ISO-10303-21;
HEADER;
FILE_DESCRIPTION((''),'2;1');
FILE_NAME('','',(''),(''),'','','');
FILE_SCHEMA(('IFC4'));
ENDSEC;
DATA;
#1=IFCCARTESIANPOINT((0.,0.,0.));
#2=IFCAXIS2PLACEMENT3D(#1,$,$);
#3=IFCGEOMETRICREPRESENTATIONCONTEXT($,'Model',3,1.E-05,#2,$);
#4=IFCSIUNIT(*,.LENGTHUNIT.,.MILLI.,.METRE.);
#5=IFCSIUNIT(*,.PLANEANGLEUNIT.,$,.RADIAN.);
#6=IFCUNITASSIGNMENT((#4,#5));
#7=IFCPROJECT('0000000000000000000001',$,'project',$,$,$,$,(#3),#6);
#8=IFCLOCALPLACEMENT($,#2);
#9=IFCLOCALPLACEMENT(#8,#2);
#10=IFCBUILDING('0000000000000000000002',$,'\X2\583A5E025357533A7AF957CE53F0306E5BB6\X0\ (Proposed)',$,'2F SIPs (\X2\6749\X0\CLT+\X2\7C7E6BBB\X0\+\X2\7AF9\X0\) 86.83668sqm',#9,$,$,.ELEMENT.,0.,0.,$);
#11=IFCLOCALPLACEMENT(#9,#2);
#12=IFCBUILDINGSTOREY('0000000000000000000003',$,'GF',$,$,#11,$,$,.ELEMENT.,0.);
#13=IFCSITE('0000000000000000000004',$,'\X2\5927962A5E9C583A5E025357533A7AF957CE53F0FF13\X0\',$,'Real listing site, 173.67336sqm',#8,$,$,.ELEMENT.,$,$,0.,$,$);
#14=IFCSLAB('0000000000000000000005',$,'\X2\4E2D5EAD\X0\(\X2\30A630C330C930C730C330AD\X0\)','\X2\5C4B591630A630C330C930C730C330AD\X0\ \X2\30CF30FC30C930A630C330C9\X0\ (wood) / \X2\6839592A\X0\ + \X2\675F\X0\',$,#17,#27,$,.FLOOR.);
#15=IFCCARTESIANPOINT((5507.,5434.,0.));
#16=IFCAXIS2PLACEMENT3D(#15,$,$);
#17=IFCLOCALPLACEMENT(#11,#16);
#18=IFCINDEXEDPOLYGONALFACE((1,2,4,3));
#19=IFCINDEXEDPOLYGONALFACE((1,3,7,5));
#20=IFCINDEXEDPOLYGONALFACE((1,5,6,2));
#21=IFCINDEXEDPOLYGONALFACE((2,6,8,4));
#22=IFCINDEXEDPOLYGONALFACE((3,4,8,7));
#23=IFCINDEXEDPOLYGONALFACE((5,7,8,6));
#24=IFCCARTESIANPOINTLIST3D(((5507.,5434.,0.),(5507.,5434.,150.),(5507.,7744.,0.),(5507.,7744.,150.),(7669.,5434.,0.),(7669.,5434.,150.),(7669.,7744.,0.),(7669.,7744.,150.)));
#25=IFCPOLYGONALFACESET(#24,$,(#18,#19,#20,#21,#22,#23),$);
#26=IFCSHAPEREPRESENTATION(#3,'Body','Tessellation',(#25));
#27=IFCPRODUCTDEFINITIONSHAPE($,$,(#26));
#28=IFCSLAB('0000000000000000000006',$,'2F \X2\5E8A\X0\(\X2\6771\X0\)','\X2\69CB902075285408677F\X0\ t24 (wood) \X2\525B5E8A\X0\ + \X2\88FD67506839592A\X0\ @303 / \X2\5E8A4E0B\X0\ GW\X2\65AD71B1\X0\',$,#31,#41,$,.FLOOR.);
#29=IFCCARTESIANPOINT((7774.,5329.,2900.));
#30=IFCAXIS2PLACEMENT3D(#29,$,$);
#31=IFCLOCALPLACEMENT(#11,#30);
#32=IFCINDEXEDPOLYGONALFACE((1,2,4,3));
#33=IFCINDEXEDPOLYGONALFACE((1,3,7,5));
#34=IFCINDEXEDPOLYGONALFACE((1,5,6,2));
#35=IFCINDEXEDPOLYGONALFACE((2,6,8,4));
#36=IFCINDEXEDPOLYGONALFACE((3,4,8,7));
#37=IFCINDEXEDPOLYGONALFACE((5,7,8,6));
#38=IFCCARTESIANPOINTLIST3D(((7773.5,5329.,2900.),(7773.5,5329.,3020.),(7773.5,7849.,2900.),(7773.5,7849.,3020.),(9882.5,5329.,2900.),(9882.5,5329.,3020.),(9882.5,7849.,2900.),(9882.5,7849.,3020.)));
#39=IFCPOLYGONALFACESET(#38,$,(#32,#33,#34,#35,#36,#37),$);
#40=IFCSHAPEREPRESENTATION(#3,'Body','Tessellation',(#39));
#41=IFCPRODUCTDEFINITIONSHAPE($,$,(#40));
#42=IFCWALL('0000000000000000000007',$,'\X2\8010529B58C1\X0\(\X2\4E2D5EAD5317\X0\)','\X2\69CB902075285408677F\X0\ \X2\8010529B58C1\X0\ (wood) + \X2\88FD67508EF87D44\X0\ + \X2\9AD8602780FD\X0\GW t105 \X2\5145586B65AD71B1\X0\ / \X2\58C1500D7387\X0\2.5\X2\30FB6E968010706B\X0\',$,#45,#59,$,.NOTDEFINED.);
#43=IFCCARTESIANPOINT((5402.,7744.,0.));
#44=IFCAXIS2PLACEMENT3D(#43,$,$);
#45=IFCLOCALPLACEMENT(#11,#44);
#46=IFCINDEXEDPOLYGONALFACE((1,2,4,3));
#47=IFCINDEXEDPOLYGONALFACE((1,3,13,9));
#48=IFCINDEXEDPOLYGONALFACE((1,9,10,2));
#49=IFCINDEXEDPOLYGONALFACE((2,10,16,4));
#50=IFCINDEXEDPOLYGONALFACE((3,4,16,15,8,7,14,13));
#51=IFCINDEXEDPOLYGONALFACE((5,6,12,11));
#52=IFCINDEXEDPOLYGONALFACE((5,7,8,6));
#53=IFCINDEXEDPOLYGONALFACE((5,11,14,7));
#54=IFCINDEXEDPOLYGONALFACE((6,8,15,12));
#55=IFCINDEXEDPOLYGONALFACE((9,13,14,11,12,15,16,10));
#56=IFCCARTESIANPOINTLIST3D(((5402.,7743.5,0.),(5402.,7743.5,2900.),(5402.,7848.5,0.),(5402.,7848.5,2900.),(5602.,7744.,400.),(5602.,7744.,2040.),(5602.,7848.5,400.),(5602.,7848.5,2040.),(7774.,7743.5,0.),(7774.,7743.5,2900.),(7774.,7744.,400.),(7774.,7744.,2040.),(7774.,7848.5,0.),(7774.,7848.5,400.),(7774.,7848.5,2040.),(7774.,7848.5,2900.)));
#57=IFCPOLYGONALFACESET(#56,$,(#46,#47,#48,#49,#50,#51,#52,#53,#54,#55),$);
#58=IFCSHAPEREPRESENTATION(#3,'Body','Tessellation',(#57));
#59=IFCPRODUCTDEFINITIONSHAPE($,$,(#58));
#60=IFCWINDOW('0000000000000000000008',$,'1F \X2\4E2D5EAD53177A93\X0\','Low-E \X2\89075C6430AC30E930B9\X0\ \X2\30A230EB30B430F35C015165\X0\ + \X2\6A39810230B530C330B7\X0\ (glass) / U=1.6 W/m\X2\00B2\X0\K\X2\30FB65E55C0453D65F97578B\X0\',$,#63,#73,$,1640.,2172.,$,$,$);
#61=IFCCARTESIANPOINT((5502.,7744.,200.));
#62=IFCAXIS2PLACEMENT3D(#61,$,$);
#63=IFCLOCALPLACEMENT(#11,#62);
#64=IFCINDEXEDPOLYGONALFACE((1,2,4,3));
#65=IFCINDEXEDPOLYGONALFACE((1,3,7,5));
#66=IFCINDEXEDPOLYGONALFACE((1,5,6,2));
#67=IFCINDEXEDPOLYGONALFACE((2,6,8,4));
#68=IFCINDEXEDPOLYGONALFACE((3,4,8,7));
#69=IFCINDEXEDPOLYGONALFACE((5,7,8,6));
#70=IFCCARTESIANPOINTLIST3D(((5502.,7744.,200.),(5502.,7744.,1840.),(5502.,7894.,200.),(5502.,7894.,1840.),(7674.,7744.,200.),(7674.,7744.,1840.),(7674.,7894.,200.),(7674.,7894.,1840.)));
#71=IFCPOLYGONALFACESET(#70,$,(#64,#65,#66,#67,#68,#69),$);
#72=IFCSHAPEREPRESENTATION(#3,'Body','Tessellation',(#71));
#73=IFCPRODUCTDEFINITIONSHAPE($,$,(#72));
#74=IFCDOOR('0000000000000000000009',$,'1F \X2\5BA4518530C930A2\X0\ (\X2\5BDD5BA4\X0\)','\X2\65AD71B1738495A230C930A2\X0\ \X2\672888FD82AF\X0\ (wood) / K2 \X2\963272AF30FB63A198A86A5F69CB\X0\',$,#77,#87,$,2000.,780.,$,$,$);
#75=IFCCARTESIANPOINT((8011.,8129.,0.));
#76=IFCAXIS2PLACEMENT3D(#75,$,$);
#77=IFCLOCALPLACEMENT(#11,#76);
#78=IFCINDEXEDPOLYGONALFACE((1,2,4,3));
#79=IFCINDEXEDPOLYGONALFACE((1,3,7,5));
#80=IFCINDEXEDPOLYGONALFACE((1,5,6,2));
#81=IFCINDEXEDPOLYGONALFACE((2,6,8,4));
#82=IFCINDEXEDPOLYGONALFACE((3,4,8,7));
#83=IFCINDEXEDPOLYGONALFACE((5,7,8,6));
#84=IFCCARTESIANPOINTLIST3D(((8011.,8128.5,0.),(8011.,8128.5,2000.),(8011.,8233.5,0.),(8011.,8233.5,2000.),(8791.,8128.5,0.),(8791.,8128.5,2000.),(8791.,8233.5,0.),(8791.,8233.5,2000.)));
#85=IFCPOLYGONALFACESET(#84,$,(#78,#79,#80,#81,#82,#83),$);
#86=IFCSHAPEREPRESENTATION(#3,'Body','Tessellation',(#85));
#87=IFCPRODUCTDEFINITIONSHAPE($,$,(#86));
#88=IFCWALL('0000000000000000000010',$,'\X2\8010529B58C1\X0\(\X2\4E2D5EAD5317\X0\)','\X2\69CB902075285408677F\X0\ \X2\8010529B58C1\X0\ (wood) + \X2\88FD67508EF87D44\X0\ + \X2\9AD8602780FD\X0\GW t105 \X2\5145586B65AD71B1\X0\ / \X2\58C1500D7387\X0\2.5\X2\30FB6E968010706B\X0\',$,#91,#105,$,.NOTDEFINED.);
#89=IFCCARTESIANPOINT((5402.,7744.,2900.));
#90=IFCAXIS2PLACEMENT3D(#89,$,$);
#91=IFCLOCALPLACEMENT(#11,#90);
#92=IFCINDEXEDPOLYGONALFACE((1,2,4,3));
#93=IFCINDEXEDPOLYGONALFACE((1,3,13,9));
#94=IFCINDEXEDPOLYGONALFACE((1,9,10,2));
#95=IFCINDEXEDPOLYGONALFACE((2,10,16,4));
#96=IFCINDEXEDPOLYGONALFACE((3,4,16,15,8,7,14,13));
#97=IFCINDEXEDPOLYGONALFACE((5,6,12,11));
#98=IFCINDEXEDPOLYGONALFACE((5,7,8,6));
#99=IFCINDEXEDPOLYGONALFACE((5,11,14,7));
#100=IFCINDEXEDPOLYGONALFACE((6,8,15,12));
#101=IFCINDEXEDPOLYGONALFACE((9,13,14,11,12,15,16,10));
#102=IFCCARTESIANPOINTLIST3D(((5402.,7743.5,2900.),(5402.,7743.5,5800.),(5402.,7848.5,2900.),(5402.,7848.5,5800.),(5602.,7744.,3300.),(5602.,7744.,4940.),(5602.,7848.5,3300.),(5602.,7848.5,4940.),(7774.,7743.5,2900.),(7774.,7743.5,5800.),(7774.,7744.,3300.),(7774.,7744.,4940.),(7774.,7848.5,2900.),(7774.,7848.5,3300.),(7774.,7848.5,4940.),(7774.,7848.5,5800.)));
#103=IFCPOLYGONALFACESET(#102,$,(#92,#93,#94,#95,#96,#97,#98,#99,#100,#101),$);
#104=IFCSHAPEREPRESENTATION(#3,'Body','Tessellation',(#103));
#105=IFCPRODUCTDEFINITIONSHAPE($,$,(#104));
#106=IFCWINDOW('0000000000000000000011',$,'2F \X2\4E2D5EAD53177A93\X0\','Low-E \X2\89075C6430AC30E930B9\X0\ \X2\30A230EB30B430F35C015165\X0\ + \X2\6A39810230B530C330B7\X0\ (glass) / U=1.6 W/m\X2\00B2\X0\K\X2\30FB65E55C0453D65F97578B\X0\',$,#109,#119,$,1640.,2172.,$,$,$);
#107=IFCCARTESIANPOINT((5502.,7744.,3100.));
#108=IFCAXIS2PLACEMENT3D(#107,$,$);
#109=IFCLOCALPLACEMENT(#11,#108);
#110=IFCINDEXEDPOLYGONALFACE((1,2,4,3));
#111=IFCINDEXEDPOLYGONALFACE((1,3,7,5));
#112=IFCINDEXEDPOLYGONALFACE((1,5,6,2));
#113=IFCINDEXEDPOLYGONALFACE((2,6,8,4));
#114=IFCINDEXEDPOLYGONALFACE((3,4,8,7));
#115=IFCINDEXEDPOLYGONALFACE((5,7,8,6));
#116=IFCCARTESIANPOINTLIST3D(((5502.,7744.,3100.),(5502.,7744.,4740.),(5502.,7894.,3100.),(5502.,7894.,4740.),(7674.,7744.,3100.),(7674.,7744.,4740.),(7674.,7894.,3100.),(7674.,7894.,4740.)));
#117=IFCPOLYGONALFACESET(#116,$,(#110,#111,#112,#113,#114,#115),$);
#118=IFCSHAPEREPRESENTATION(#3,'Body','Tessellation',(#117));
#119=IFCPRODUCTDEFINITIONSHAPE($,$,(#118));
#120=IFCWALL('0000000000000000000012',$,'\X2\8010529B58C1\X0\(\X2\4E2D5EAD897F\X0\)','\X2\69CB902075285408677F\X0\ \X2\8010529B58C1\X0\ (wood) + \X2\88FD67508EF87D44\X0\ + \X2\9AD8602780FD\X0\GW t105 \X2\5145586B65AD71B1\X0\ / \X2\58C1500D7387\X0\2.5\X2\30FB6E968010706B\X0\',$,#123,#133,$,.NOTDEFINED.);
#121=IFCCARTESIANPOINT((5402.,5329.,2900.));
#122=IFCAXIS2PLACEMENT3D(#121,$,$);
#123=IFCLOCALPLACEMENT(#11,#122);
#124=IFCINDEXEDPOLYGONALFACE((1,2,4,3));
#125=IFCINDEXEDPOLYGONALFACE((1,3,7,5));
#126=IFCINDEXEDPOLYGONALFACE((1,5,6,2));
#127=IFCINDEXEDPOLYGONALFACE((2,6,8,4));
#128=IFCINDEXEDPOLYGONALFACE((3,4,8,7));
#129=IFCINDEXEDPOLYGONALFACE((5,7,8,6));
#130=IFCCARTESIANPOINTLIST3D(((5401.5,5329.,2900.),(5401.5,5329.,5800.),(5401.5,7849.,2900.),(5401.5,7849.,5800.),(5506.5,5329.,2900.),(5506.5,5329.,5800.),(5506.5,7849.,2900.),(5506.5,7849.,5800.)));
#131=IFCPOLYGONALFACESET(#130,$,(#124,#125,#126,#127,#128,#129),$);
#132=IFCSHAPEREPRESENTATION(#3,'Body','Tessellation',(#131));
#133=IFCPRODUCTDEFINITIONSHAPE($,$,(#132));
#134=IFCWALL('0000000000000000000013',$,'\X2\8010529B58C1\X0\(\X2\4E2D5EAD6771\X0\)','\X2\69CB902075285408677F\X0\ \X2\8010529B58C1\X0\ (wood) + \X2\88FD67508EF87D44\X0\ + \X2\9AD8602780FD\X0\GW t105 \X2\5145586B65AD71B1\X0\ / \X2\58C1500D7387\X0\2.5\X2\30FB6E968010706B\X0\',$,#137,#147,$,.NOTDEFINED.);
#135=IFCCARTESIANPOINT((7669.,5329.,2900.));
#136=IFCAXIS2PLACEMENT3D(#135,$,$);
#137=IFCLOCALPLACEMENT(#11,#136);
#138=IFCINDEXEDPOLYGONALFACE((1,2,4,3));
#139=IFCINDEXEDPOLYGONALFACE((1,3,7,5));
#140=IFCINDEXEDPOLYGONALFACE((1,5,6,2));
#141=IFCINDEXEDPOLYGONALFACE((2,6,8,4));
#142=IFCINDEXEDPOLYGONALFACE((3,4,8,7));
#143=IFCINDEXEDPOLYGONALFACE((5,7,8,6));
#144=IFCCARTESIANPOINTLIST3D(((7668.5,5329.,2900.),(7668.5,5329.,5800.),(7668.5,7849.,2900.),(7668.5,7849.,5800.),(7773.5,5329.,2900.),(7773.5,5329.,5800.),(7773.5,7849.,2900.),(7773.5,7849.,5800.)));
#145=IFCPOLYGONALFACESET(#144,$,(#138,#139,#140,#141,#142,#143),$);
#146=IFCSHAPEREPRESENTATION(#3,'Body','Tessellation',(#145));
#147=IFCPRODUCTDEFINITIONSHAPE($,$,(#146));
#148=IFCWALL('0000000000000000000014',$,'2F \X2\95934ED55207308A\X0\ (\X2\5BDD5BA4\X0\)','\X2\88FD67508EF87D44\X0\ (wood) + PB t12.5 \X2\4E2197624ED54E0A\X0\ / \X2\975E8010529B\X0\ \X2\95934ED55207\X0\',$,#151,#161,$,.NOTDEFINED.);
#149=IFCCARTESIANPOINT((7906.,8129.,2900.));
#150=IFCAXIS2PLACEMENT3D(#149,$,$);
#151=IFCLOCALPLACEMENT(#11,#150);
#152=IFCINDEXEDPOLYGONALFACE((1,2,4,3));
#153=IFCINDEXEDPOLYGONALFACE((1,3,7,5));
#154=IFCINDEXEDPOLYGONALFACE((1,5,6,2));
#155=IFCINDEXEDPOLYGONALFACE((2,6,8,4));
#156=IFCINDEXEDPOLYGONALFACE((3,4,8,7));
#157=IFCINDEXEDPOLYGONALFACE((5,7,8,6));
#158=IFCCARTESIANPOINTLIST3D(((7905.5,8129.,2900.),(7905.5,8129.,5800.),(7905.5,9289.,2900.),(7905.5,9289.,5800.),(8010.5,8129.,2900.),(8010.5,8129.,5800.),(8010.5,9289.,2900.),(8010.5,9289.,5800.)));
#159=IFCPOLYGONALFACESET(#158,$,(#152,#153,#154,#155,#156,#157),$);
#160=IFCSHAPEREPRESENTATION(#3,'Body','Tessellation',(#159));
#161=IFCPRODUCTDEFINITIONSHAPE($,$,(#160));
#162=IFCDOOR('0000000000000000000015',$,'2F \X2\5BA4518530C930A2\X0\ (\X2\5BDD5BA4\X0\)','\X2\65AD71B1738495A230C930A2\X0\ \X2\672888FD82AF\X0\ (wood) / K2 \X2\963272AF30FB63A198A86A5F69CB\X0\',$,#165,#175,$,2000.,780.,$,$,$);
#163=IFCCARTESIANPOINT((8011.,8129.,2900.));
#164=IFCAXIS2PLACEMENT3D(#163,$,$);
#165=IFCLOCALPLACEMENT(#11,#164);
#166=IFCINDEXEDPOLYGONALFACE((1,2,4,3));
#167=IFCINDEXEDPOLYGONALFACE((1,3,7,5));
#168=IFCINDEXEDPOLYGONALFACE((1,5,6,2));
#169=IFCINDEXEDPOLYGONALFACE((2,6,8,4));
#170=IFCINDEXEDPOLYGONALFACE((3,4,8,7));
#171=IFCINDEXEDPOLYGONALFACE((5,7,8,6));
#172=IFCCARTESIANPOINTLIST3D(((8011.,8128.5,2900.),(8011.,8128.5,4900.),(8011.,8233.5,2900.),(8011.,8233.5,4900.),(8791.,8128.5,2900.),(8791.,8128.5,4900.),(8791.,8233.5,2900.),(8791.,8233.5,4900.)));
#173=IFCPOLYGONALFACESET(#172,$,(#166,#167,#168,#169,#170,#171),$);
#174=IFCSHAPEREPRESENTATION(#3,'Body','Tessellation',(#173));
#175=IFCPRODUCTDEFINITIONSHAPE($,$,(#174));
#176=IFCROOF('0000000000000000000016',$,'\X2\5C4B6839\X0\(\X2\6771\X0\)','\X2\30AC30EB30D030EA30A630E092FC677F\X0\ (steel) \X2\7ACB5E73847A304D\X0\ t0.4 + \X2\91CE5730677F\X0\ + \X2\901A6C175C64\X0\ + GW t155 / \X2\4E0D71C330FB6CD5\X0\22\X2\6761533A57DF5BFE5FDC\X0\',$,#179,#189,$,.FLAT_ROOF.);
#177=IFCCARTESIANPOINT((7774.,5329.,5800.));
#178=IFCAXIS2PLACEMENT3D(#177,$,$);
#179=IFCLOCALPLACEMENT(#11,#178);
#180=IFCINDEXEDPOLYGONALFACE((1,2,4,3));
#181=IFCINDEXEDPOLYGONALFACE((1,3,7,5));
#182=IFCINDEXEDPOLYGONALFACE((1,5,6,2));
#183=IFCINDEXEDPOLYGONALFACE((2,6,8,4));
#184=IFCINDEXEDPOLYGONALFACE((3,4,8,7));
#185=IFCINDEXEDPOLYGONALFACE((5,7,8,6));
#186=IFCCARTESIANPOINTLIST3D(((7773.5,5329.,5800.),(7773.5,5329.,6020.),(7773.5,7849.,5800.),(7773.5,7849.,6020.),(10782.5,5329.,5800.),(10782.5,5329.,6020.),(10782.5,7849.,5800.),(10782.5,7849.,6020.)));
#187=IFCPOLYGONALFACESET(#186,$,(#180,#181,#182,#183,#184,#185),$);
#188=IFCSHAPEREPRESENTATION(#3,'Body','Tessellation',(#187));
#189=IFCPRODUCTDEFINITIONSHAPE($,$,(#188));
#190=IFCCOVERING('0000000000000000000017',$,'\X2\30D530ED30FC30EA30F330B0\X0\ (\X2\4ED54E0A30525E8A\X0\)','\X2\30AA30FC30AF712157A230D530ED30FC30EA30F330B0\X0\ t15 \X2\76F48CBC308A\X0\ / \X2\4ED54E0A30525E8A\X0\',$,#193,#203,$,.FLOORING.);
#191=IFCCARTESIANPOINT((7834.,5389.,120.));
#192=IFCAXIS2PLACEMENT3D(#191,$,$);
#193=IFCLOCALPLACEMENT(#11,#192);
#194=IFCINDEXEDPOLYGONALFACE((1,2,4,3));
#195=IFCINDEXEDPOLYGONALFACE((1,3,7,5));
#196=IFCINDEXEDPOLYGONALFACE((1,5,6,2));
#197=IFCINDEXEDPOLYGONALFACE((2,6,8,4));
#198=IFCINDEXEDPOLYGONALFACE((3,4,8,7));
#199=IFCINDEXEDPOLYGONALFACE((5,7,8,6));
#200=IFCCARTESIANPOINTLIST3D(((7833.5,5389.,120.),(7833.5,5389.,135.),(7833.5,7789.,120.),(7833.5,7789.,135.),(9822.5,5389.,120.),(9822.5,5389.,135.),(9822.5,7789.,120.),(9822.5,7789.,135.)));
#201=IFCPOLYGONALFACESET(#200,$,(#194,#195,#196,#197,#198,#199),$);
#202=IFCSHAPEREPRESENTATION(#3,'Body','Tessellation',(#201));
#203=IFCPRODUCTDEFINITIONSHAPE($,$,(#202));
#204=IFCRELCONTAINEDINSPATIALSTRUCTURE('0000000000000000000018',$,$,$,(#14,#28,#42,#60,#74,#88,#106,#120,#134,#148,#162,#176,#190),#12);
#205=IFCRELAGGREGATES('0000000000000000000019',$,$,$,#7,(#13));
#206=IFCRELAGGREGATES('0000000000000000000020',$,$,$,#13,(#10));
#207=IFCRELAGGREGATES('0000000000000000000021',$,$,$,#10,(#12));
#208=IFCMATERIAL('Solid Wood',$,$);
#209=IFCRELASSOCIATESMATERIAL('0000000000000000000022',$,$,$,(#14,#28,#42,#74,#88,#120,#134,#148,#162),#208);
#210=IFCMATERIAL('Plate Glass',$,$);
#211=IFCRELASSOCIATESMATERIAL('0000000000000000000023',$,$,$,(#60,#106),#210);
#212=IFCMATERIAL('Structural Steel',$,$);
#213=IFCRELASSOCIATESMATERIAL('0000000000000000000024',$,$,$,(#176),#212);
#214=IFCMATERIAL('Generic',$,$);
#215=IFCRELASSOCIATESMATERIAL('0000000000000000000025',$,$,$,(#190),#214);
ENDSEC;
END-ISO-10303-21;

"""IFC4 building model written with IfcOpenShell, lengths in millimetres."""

from ifc_helpers import new_model, si_unit, frame, frame_2d, origin, place, context, project, spatial, rectangle, extrude, material, element, fill, save


model = new_model("IFC4")

# Units and contexts
model_context = context("Model", 3, precision=1e-05, world=origin())
ifc_project = project(units=[si_unit("LENGTHUNIT", "METRE", prefix="MILLI"), si_unit("PLANEANGLEUNIT", "RADIAN")], contexts=[model_context])

# Site, building, storey
site_placement = place(None, origin())
site = spatial("IfcSite", under=ifc_project, at=site_placement, Name="大阪府堺市南区竹城台３", ObjectType="Real listing site, 173.67336sqm", CompositionType="ELEMENT", RefElevation=0.0)
building_placement = place(site_placement, origin())
building = spatial("IfcBuilding", under=site, at=building_placement, Name="堺市南区竹城台の家 (Proposed)", ObjectType="2F SIPs (杉CLT+籾殻+竹) 86.83668sqm", CompositionType="ELEMENT", ElevationOfRefHeight=0.0, ElevationOfTerrain=0.0)
storey_placement = place(building_placement, origin())
storey = spatial("IfcBuildingStorey", under=building, at=storey_placement, Name="GF", CompositionType="ELEMENT", Elevation=0.0)

# Slabs
ifc_material_1 = material(Name="Solid Wood")
slab_1_placement = place(storey_placement, frame((5507.0, 5434.0, 0.0)))
element("IfcSlab", 1, at=slab_1_placement, inside=storey, material=ifc_material_1, Name="中庭(ウッドデッキ)", Description="屋外ウッドデッキ ハードウッド (wood) / 根太 + 束", PredefinedType="FLOOR", context=model_context, shape_type="SweptSolid", body=[
    extrude(rectangle(XDim=2162.0, YDim=2310.0, at=frame_2d((1081.0, 1155.0))), frame((5507.0, 5434.0, 0.0)), (0.0, 0.0, 1.0), 150.0),
])
slab_2_placement = place(storey_placement, frame((7774.0, 5329.0, 2900.0)))
element("IfcSlab", 2, at=slab_2_placement, inside=storey, material=ifc_material_1, Name="2F 床(東)", Description="構造用合板 t24 (wood) 剛床 + 製材根太 @303 / 床下 GW断熱", PredefinedType="FLOOR", context=model_context, shape_type="SweptSolid", body=[
    extrude(rectangle(XDim=2109.0, YDim=2520.0, at=frame_2d((1054.0, 1260.0))), frame((7774.0, 5329.0, 2900.0)), (0.0, 0.0, 1.0), 120.0),
])

# Wall, opening, window
wall_1_placement = place(storey_placement, frame((5402.0, 7744.0, 0.0)))
wall_1 = element("IfcWall", 3, at=wall_1_placement, inside=storey, material=ifc_material_1, Name="耐力壁(中庭北)", Description="構造用合板 耐力壁 (wood) + 製材軸組 + 高性能GW t105 充填断熱 / 壁倍率2.5・準耐火", PredefinedType="NOTDEFINED", context=model_context, shape_type="SweptSolid", body=[
    extrude(rectangle(XDim=2372.0, YDim=105.0, at=frame_2d((1186.0, 52.0))), frame((5402.0, 7744.0, 0.0)), (0.0, 0.0, 1.0), 2900.0),
])
opening_1_placement = place(storey_placement, frame((5502.0, 7744.0, 200.0)))
opening_1 = element("IfcOpeningElement", 4, at=opening_1_placement, cuts=wall_1, PredefinedType="NOTDEFINED", context=model_context, shape_type="SweptSolid", body=[
    extrude(rectangle(XDim=2172.0, YDim=150.0, at=frame_2d((1086.0, 75.0))), frame((5502.0, 7744.0, 200.0)), (0.0, 0.0, 1.0), 1640.0),
])
ifc_material_2 = material(Name="Plate Glass")
window_1_placement = place(storey_placement, frame((5502.0, 7744.0, 200.0)))
window_1 = element("IfcWindow", 5, at=window_1_placement, inside=storey, material=ifc_material_2, Name="1F 中庭北窓", Description="Low-E 複層ガラス アルゴン封入 + 樹脂サッシ (glass) / U=1.6 W/m²K・日射取得型", OverallHeight=1640.0, OverallWidth=2172.0, context=model_context, shape_type="SweptSolid", body=[
    extrude(rectangle(XDim=2172.0, YDim=150.0, at=frame_2d((1086.0, 75.0))), frame((5502.0, 7744.0, 200.0)), (0.0, 0.0, 1.0), 1640.0),
])
fill(opening_1, window_1)

# Door
door_1_placement = place(storey_placement, frame((8011.0, 8129.0, 0.0)))
element("IfcDoor", 6, at=door_1_placement, inside=storey, material=ifc_material_1, Name="1F 室内ドア (寝室)", Description="断熱玄関ドア 木製芯 (wood) / K2 防犯・採風機構", OverallHeight=2000.0, OverallWidth=780.0, context=model_context, shape_type="SweptSolid", body=[
    extrude(rectangle(XDim=780.0, YDim=105.0, at=frame_2d((390.0, 52.0))), frame((8011.0, 8129.0, 0.0)), (0.0, 0.0, 1.0), 2000.0),
])

# Wall, opening, window
wall_2_placement = place(storey_placement, frame((5402.0, 7744.0, 2900.0)))
wall_2 = element("IfcWall", 7, at=wall_2_placement, inside=storey, material=ifc_material_1, Name="耐力壁(中庭北)", Description="構造用合板 耐力壁 (wood) + 製材軸組 + 高性能GW t105 充填断熱 / 壁倍率2.5・準耐火", PredefinedType="NOTDEFINED", context=model_context, shape_type="SweptSolid", body=[
    extrude(rectangle(XDim=2372.0, YDim=105.0, at=frame_2d((1186.0, 52.0))), frame((5402.0, 7744.0, 2900.0)), (0.0, 0.0, 1.0), 2900.0),
])
opening_2_placement = place(storey_placement, frame((5502.0, 7744.0, 3100.0)))
opening_2 = element("IfcOpeningElement", 8, at=opening_2_placement, cuts=wall_2, PredefinedType="NOTDEFINED", context=model_context, shape_type="SweptSolid", body=[
    extrude(rectangle(XDim=2172.0, YDim=150.0, at=frame_2d((1086.0, 75.0))), frame((5502.0, 7744.0, 3100.0)), (0.0, 0.0, 1.0), 1640.0),
])
window_2_placement = place(storey_placement, frame((5502.0, 7744.0, 3100.0)))
window_2 = element("IfcWindow", 9, at=window_2_placement, inside=storey, material=ifc_material_2, Name="2F 中庭北窓", Description="Low-E 複層ガラス アルゴン封入 + 樹脂サッシ (glass) / U=1.6 W/m²K・日射取得型", OverallHeight=1640.0, OverallWidth=2172.0, context=model_context, shape_type="SweptSolid", body=[
    extrude(rectangle(XDim=2172.0, YDim=150.0, at=frame_2d((1086.0, 75.0))), frame((5502.0, 7744.0, 3100.0)), (0.0, 0.0, 1.0), 1640.0),
])
fill(opening_2, window_2)

# Walls
wall_3_placement = place(storey_placement, frame((5402.0, 5329.0, 2900.0)))
element("IfcWall", 10, at=wall_3_placement, inside=storey, material=ifc_material_1, Name="耐力壁(中庭西)", Description="構造用合板 耐力壁 (wood) + 製材軸組 + 高性能GW t105 充填断熱 / 壁倍率2.5・準耐火", PredefinedType="NOTDEFINED", context=model_context, shape_type="SweptSolid", body=[
    extrude(rectangle(XDim=105.0, YDim=2520.0, at=frame_2d((52.0, 1260.0))), frame((5402.0, 5329.0, 2900.0)), (0.0, 0.0, 1.0), 2900.0),
])
wall_4_placement = place(storey_placement, frame((7669.0, 5329.0, 2900.0)))
element("IfcWall", 11, at=wall_4_placement, inside=storey, material=ifc_material_1, Name="耐力壁(中庭東)", Description="構造用合板 耐力壁 (wood) + 製材軸組 + 高性能GW t105 充填断熱 / 壁倍率2.5・準耐火", PredefinedType="NOTDEFINED", context=model_context, shape_type="SweptSolid", body=[
    extrude(rectangle(XDim=105.0, YDim=2520.0, at=frame_2d((52.0, 1260.0))), frame((7669.0, 5329.0, 2900.0)), (0.0, 0.0, 1.0), 2900.0),
])
wall_5_placement = place(storey_placement, frame((7906.0, 8129.0, 2900.0)))
element("IfcWall", 12, at=wall_5_placement, inside=storey, material=ifc_material_1, Name="2F 間仕切り (寝室)", Description="製材軸組 (wood) + PB t12.5 両面仕上 / 非耐力 間仕切", PredefinedType="NOTDEFINED", context=model_context, shape_type="SweptSolid", body=[
    extrude(rectangle(XDim=105.0, YDim=1160.0, at=frame_2d((52.0, 580.0))), frame((7906.0, 8129.0, 2900.0)), (0.0, 0.0, 1.0), 2900.0),
])

# Door
door_2_placement = place(storey_placement, frame((8011.0, 8129.0, 2900.0)))
element("IfcDoor", 13, at=door_2_placement, inside=storey, material=ifc_material_1, Name="2F 室内ドア (寝室)", Description="断熱玄関ドア 木製芯 (wood) / K2 防犯・採風機構", OverallHeight=2000.0, OverallWidth=780.0, context=model_context, shape_type="SweptSolid", body=[
    extrude(rectangle(XDim=780.0, YDim=105.0, at=frame_2d((390.0, 52.0))), frame((8011.0, 8129.0, 2900.0)), (0.0, 0.0, 1.0), 2000.0),
])

# Roof
ifc_material_3 = material(Name="Structural Steel")
roof_placement = place(storey_placement, frame((7774.0, 5329.0, 5800.0)))
element("IfcRoof", 14, at=roof_placement, inside=storey, material=ifc_material_3, Name="屋根(東)", Description="ガルバリウム鋼板 (steel) 立平葺き t0.4 + 野地板 + 通気層 + GW t155 / 不燃・法22条区域対応", PredefinedType="FLAT_ROOF", context=model_context, shape_type="SweptSolid", body=[
    extrude(rectangle(XDim=3009.0, YDim=2520.0, at=frame_2d((1504.0, 1260.0))), frame((7774.0, 5329.0, 5800.0)), (0.0, 0.0, 1.0), 220.0),
])

# Covering
ifc_material_4 = material(Name="Generic")
covering_1_placement = place(storey_placement, frame((7834.0, 5389.0, 120.0)))
element("IfcCovering", 15, at=covering_1_placement, inside=storey, material=ifc_material_4, Name="フローリング (仕上げ床)", Description="オーク無垢フローリング t15 直貼り / 仕上げ床", PredefinedType="FLOORING", context=model_context, shape_type="SweptSolid", body=[
    extrude(rectangle(XDim=1989.0, YDim=2400.0, at=frame_2d((994.0, 1200.0))), frame((7834.0, 5389.0, 120.0)), (0.0, 0.0, 1.0), 15.0),
])

save(model, "model.ifc")
